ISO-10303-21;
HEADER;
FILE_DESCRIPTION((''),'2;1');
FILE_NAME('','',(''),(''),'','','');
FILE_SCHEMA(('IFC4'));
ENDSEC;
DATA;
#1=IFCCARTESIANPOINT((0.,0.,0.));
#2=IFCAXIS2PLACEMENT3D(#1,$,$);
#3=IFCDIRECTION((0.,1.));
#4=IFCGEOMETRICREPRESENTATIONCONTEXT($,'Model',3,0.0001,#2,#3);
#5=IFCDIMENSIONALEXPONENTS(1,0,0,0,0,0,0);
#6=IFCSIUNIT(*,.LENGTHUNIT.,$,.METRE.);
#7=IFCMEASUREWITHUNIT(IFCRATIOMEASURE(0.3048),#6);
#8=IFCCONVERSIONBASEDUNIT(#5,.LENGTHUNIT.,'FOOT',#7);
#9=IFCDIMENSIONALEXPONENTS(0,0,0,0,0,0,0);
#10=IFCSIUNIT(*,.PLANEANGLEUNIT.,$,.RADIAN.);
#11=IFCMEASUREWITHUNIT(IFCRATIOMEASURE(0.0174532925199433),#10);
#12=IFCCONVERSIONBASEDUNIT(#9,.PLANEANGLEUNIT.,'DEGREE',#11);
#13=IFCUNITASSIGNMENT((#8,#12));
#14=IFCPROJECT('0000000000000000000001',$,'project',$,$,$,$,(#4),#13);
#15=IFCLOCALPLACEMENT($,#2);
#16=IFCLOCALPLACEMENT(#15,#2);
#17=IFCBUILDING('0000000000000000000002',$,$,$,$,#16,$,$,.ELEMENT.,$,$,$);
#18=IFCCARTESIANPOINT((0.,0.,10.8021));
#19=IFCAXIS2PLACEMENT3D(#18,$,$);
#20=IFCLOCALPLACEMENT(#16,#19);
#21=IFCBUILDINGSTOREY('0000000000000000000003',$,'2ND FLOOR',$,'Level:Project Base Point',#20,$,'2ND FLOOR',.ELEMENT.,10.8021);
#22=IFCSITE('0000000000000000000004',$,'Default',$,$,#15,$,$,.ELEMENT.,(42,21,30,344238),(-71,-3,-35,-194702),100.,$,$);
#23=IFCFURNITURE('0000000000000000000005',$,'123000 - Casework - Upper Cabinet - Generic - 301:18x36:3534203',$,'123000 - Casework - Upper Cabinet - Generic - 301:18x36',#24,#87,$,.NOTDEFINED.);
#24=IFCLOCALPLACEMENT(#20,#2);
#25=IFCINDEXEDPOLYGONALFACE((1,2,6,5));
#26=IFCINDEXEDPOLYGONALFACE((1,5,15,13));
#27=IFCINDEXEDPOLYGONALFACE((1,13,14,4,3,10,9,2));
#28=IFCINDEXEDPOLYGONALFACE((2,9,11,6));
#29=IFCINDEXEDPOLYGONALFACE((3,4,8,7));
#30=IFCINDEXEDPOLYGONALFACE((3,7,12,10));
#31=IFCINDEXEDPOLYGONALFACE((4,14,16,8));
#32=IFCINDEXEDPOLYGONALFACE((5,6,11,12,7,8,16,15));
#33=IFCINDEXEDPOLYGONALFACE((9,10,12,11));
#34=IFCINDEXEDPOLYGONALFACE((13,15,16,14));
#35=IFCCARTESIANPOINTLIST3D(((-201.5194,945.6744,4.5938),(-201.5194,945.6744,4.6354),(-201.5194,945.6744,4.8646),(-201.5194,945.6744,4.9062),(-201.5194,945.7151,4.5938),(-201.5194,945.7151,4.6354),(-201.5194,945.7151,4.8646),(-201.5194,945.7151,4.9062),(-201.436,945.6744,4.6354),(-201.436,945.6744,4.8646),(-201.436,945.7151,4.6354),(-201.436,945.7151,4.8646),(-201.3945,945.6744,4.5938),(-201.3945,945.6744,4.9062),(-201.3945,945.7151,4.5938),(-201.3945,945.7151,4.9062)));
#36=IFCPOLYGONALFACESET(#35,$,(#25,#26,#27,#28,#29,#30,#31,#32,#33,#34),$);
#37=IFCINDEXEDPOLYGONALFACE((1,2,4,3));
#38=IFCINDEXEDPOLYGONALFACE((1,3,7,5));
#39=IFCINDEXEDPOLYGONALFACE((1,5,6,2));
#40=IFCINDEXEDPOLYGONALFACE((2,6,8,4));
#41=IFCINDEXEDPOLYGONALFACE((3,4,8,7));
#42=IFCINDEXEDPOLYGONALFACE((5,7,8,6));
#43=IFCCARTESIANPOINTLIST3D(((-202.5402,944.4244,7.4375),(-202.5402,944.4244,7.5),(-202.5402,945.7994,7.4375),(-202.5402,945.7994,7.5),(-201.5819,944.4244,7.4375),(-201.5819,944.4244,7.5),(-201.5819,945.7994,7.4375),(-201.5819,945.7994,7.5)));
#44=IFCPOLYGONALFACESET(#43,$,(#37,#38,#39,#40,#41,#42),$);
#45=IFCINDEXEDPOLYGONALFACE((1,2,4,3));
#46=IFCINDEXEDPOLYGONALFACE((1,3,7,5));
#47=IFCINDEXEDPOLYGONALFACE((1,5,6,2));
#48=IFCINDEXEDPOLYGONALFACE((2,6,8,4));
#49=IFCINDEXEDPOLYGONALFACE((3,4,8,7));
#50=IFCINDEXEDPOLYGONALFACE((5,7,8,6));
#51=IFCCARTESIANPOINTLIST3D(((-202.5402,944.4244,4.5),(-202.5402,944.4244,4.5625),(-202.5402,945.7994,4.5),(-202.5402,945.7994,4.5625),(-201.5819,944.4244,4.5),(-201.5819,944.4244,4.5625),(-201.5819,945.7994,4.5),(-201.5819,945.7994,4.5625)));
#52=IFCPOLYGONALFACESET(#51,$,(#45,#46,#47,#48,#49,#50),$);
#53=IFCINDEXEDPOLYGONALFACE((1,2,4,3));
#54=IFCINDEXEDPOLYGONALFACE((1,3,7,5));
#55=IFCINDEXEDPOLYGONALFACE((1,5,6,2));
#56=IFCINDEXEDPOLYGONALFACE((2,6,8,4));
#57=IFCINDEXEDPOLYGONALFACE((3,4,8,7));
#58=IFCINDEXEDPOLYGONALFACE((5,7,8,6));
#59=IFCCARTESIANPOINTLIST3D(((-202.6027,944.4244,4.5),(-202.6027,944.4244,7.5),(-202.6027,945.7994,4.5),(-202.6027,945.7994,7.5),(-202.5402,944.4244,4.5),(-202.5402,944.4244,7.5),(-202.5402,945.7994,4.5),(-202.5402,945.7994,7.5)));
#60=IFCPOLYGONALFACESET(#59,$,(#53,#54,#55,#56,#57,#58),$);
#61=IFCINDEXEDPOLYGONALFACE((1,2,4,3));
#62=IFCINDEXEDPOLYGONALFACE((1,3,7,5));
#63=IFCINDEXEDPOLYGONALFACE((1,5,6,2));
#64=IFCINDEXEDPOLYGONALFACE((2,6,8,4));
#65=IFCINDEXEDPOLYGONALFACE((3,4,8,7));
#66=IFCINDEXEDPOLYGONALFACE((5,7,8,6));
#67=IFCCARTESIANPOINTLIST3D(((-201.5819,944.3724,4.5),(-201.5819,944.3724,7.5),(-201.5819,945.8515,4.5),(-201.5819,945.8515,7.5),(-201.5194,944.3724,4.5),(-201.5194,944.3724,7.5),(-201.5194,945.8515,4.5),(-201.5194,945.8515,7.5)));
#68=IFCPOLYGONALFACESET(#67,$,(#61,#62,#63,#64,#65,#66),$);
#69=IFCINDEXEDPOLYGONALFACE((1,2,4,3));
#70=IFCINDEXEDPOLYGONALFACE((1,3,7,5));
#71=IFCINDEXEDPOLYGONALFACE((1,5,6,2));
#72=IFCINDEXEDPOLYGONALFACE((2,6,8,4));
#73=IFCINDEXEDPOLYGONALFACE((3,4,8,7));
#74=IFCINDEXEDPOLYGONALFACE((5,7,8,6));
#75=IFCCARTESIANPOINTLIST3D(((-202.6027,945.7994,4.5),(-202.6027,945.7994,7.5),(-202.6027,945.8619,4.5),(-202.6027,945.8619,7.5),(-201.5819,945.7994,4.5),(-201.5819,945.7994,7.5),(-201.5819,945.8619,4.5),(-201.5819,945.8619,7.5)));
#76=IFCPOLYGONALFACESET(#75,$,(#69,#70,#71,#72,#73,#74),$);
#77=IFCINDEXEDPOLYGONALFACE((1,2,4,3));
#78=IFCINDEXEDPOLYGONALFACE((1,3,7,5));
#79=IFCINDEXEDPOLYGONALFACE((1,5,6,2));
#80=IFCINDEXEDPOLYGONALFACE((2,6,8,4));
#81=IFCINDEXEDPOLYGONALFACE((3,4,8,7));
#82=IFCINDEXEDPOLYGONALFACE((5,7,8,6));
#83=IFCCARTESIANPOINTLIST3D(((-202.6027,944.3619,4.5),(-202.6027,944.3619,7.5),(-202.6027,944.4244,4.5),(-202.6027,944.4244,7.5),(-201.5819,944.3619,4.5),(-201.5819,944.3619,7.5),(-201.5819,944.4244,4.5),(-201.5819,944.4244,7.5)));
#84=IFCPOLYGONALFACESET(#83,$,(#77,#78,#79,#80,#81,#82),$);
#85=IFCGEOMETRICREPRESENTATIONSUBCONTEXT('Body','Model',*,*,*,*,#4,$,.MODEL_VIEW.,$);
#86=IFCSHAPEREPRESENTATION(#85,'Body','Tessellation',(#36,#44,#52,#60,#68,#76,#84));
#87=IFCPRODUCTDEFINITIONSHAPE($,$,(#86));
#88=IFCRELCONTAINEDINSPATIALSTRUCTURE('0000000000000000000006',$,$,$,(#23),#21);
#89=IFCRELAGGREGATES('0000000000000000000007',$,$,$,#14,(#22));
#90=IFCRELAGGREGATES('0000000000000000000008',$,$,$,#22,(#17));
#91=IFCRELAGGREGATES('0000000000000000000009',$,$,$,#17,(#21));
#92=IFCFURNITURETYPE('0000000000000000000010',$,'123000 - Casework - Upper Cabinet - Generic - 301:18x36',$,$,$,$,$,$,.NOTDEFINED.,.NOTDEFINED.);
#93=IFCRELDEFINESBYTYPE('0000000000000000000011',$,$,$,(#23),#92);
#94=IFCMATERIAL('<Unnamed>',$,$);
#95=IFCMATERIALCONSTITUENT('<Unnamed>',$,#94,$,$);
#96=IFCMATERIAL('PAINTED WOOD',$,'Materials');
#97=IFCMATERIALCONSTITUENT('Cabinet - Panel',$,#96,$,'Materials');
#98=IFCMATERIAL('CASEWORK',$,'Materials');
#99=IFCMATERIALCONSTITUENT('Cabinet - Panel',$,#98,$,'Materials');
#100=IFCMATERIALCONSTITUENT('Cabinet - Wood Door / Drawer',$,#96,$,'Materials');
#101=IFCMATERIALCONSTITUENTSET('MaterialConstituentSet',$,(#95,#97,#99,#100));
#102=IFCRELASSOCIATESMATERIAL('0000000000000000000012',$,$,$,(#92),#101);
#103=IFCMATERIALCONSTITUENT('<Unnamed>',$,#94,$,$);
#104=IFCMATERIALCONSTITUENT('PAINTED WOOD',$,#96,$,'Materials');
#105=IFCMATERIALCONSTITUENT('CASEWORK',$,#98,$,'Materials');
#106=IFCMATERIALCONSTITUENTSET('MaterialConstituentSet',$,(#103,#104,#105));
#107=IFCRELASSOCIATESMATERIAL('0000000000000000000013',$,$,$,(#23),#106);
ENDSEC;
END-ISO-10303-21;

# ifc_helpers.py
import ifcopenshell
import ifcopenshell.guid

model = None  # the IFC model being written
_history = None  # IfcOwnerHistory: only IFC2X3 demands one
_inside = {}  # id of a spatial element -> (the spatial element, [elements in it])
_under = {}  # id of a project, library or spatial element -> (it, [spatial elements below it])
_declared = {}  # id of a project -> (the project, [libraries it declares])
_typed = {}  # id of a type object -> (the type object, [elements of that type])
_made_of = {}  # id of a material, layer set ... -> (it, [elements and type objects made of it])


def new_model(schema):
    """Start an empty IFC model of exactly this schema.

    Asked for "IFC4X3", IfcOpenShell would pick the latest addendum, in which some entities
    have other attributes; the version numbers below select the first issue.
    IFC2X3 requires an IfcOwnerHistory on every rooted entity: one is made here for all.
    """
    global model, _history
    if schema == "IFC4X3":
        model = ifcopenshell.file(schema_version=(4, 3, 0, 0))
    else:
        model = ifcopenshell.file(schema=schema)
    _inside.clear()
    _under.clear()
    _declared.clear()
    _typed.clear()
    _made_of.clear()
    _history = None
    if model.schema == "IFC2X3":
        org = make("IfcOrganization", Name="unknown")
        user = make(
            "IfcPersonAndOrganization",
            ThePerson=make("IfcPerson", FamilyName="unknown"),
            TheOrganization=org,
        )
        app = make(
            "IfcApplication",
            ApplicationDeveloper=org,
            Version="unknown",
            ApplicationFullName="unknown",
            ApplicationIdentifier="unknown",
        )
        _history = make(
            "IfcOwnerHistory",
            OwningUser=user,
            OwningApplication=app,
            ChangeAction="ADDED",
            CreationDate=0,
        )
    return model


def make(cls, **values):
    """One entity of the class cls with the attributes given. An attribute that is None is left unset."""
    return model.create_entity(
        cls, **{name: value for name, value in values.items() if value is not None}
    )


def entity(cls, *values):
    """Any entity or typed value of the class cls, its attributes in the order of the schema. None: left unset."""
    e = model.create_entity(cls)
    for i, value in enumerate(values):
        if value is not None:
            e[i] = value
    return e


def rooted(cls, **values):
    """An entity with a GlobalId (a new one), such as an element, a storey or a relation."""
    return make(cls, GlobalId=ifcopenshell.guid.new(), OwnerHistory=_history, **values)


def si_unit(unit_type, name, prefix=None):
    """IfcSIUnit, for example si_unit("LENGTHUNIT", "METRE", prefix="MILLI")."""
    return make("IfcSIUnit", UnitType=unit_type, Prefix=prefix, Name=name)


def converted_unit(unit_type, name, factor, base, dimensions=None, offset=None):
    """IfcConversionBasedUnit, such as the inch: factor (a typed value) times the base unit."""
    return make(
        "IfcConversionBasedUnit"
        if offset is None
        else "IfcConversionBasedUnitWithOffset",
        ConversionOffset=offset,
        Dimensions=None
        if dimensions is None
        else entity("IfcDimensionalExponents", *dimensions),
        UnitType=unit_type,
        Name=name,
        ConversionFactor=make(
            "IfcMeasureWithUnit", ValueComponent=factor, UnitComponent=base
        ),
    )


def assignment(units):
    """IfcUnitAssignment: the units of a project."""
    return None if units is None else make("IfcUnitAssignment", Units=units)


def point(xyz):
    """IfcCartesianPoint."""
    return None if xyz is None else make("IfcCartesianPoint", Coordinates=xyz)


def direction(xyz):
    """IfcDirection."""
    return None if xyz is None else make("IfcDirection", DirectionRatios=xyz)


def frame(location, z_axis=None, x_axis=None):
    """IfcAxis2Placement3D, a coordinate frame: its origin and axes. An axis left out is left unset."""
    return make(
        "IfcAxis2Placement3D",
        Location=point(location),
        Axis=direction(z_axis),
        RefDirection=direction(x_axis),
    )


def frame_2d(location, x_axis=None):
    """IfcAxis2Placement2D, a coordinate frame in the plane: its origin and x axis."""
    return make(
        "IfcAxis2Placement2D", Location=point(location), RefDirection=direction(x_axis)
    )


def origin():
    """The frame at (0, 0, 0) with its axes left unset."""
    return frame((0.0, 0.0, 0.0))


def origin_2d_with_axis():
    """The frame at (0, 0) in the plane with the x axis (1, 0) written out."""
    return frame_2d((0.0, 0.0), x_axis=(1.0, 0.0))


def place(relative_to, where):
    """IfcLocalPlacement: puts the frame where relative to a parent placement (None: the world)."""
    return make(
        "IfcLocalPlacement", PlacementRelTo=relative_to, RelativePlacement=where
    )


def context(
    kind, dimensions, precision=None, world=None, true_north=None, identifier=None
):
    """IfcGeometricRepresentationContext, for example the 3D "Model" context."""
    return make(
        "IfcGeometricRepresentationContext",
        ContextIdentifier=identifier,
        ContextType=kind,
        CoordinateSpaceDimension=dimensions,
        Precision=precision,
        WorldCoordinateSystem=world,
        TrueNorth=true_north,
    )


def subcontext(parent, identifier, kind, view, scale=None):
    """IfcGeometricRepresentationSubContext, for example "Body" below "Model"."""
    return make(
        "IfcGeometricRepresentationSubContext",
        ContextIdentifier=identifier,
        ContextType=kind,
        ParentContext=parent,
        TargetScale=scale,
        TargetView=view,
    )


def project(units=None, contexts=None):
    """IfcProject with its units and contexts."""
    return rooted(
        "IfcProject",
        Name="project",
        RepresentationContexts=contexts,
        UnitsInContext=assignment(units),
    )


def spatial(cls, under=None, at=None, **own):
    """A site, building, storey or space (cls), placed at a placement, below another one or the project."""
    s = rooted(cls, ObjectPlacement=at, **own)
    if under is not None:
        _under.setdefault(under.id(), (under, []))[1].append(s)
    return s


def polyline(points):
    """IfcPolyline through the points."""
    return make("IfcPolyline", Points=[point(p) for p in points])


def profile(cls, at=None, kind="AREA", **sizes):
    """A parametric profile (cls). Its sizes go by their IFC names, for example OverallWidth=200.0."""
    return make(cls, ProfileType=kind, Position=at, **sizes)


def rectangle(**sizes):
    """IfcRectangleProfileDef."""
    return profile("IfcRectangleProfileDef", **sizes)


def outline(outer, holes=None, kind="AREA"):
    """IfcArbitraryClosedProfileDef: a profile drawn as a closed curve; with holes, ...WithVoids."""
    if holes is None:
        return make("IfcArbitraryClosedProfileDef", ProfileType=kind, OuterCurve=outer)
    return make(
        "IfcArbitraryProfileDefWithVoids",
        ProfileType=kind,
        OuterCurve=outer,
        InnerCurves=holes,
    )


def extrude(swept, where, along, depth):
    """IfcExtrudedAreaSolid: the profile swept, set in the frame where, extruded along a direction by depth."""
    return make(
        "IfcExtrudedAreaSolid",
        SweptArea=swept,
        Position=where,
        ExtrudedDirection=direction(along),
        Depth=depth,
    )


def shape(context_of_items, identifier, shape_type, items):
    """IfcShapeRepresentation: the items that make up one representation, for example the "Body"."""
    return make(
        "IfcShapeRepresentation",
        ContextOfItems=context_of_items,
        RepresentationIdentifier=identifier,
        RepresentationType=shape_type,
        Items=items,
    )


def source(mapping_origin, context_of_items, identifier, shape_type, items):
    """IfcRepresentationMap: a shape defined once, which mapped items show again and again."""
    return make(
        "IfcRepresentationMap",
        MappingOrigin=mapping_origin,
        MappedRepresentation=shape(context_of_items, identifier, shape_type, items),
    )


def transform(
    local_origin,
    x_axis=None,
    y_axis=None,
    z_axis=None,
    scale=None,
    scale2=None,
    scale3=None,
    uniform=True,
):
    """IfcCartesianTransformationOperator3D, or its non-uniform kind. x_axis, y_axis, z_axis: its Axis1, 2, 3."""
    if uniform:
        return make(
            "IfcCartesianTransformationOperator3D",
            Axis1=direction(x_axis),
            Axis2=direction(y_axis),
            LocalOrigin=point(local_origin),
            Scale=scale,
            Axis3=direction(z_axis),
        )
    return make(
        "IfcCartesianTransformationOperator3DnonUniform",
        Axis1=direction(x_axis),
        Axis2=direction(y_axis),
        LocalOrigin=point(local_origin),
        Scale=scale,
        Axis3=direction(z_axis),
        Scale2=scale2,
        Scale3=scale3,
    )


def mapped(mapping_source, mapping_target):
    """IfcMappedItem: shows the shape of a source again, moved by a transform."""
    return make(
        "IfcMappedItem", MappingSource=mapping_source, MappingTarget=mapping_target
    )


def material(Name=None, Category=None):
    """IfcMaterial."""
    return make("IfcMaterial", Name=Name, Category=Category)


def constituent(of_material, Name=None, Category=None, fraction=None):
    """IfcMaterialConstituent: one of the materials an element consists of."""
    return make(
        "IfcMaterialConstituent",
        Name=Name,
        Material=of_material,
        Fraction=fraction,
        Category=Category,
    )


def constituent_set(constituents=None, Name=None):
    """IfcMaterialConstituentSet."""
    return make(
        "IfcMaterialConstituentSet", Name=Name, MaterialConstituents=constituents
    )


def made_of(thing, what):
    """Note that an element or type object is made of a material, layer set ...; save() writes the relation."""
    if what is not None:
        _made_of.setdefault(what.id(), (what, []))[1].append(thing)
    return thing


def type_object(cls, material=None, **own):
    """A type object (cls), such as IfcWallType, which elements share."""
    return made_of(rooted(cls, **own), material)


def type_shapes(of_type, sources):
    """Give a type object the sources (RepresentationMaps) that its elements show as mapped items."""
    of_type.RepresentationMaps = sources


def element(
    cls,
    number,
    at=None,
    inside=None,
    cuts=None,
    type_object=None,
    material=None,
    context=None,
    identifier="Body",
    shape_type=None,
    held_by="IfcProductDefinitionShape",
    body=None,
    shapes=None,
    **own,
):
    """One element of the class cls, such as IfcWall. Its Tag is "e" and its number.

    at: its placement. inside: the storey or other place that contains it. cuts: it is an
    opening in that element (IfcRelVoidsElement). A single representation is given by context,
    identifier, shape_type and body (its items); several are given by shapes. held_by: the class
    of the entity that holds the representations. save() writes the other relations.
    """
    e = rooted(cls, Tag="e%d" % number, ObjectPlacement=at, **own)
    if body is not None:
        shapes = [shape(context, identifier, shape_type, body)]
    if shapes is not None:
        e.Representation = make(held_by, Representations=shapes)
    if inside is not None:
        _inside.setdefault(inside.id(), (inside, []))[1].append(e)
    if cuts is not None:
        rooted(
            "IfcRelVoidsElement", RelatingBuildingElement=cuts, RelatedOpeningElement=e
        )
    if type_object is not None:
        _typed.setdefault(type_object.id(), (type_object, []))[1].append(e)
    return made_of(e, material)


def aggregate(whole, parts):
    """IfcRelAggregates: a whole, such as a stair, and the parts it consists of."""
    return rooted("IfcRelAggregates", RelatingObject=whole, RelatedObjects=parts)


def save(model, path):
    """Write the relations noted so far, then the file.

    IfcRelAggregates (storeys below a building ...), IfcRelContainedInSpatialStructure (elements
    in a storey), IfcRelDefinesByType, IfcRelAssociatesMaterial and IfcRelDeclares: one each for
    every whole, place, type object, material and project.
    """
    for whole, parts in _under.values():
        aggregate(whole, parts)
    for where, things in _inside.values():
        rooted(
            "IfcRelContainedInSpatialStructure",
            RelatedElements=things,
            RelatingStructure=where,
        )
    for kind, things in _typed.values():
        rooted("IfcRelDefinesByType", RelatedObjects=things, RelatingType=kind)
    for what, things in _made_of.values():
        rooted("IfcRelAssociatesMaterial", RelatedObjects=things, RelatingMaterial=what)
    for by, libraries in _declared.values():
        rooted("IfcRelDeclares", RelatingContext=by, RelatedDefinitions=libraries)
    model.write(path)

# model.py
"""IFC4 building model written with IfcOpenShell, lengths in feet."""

from ifc_helpers import new_model, entity, si_unit, converted_unit, direction, frame, frame_2d, origin, origin_2d_with_axis, place, context, subcontext, project, spatial, polyline, rectangle, outline, extrude, source, transform, mapped, material, constituent, constituent_set, type_object, type_shapes, element, save


model = new_model("IFC4")

# Units and contexts
model_context = context("Model", 3, precision=0.0001, world=origin(), true_north=direction((0.0, 1.0)))
body_context = subcontext(model_context, "Body", "Model", "MODEL_VIEW")
ifc_project = project(units=[converted_unit("LENGTHUNIT", "FOOT", entity("IfcRatioMeasure", 0.3048), si_unit("LENGTHUNIT", "METRE"), dimensions=[1, 0, 0, 0, 0, 0, 0]), converted_unit("PLANEANGLEUNIT", "DEGREE", entity("IfcRatioMeasure", 0.0174532925199433), si_unit("PLANEANGLEUNIT", "RADIAN"), dimensions=[0, 0, 0, 0, 0, 0, 0])], contexts=[model_context])

# Site, building, storey
site_placement = place(None, origin())
site = spatial("IfcSite", under=ifc_project, at=site_placement, Name="Default", CompositionType="ELEMENT", RefLatitude=(42, 21, 30, 344238), RefLongitude=(-71, -3, -35, -194702), RefElevation=100.0)
building_placement = place(site_placement, origin())
building = spatial("IfcBuilding", under=site, at=building_placement, CompositionType="ELEMENT")
storey_placement = place(building_placement, frame((0.0, 0.0, 10.8021)))
storey = spatial("IfcBuildingStorey", under=building, at=storey_placement, Name="2ND FLOOR", ObjectType="Level:Project Base Point", LongName="2ND FLOOR", CompositionType="ELEMENT", Elevation=10.8021)

# Furniture
ifc_material_1 = material(Name="CASEWORK", Category="Materials")
ifc_material_2 = material(Name="PAINTED WOOD", Category="Materials")
ifc_material_3 = material(Name="<Unnamed>")
ifc_constituent_1 = constituent(ifc_material_3, Name="<Unnamed>")
ifc_constituent_2 = constituent(ifc_material_2, Name="PAINTED WOOD", Category="Materials")
ifc_constituent_3 = constituent(ifc_material_1, Name="CASEWORK", Category="Materials")
ifc_constituent_set_1 = constituent_set(constituents=[ifc_constituent_1, ifc_constituent_2, ifc_constituent_3], Name="MaterialConstituentSet")
ifc_constituent_4 = constituent(ifc_material_3, Name="<Unnamed>")
ifc_constituent_5 = constituent(ifc_material_2, Name="Cabinet - Panel", Category="Materials")
ifc_constituent_6 = constituent(ifc_material_1, Name="Cabinet - Panel", Category="Materials")
ifc_constituent_7 = constituent(ifc_material_2, Name="Cabinet - Wood Door / Drawer", Category="Materials")
ifc_constituent_set_2 = constituent_set(constituents=[ifc_constituent_4, ifc_constituent_5, ifc_constituent_6, ifc_constituent_7], Name="MaterialConstituentSet")
furniture_type_1 = type_object("IfcFurnitureType", Name="123000 - Casework - Upper Cabinet - Generic - 301:18x36", AssemblyPlace="NOTDEFINED", PredefinedType="NOTDEFINED", material=ifc_constituent_set_2)
shared_shape_1 = source(origin(), body_context, "Body", "SweptSolid", [
    extrude(outline(polyline([(-0.0521, -0.1146), (-0.0521, -0.1562), (0.0729, -0.1562), (0.0729, 0.1562), (-0.0521, 0.1562), (-0.0521, 0.1146), (0.0313, 0.1146), (0.0313, -0.1146), (-0.0521, -0.1146)])), frame((0.1468, 1.1354, 0.25), z_axis=(-1.0, 0.0, 0.0), x_axis=(0.0, 1.0, 0.0)), (0.0, 0.0, -1.0), 0.0407),
    extrude(rectangle(XDim=0.9583, YDim=1.375, at=frame_2d((0.0, 0.0), x_axis=(1.0, 0.0))), frame((0.75, 0.5417, 2.9375), z_axis=(0.0, 0.0, 1.0), x_axis=(0.0, 1.0, 0.0)), (0.0, 0.0, 1.0), 0.0625),
    extrude(rectangle(XDim=0.9583, YDim=1.375, at=frame_2d((0.0, 0.0), x_axis=(1.0, 0.0))), frame((0.75, 0.5417, 0.0), z_axis=(0.0, 0.0, 1.0), x_axis=(0.0, 1.0, 0.0)), (0.0, 0.0, 1.0), 0.0625),
    extrude(rectangle(XDim=1.375, YDim=0.0625, at=origin_2d_with_axis()), frame((0.75, 0.0313, 0.0), z_axis=(0.0, 0.0, 1.0), x_axis=(-1.0, 0.0, 0.0)), (0.0, 0.0, 1.0), 3.0),
    extrude(rectangle(XDim=1.4792, YDim=0.0625, at=origin_2d_with_axis()), frame((0.75, 1.0521, 0.0)), (0.0, 0.0, 1.0), 3.0),
    extrude(rectangle(XDim=1.0208, YDim=0.0625, at=origin_2d_with_axis()), frame((0.0312, 0.5104, 0.0), z_axis=(0.0, 0.0, 1.0), x_axis=(0.0, 1.0, 0.0)), (0.0, 0.0, 1.0), 3.0),
    extrude(rectangle(XDim=1.0208, YDim=0.0625, at=origin_2d_with_axis()), frame((1.4688, 0.5104, 0.0), z_axis=(0.0, 0.0, 1.0), x_axis=(0.0, 1.0, 0.0)), (0.0, 0.0, 1.0), 3.0),
])
type_shapes(furniture_type_1, [shared_shape_1])
furniture_1_placement = place(storey_placement, frame((-202.6027, 945.8619, 4.5), z_axis=(0.0, 0.0, 1.0), x_axis=(0.0, -1.0, 0.0)))
element("IfcFurniture", 1, at=furniture_1_placement, inside=storey, type_object=furniture_type_1, material=ifc_constituent_set_1, Name="123000 - Casework - Upper Cabinet - Generic - 301:18x36:3534203", ObjectType="123000 - Casework - Upper Cabinet - Generic - 301:18x36", PredefinedType="NOTDEFINED", context=body_context, shape_type="MappedRepresentation", body=[
    mapped(shared_shape_1, transform((0.0, 0.0, 0.0), scale=1.0)),
])

save(model, "model.ifc")
